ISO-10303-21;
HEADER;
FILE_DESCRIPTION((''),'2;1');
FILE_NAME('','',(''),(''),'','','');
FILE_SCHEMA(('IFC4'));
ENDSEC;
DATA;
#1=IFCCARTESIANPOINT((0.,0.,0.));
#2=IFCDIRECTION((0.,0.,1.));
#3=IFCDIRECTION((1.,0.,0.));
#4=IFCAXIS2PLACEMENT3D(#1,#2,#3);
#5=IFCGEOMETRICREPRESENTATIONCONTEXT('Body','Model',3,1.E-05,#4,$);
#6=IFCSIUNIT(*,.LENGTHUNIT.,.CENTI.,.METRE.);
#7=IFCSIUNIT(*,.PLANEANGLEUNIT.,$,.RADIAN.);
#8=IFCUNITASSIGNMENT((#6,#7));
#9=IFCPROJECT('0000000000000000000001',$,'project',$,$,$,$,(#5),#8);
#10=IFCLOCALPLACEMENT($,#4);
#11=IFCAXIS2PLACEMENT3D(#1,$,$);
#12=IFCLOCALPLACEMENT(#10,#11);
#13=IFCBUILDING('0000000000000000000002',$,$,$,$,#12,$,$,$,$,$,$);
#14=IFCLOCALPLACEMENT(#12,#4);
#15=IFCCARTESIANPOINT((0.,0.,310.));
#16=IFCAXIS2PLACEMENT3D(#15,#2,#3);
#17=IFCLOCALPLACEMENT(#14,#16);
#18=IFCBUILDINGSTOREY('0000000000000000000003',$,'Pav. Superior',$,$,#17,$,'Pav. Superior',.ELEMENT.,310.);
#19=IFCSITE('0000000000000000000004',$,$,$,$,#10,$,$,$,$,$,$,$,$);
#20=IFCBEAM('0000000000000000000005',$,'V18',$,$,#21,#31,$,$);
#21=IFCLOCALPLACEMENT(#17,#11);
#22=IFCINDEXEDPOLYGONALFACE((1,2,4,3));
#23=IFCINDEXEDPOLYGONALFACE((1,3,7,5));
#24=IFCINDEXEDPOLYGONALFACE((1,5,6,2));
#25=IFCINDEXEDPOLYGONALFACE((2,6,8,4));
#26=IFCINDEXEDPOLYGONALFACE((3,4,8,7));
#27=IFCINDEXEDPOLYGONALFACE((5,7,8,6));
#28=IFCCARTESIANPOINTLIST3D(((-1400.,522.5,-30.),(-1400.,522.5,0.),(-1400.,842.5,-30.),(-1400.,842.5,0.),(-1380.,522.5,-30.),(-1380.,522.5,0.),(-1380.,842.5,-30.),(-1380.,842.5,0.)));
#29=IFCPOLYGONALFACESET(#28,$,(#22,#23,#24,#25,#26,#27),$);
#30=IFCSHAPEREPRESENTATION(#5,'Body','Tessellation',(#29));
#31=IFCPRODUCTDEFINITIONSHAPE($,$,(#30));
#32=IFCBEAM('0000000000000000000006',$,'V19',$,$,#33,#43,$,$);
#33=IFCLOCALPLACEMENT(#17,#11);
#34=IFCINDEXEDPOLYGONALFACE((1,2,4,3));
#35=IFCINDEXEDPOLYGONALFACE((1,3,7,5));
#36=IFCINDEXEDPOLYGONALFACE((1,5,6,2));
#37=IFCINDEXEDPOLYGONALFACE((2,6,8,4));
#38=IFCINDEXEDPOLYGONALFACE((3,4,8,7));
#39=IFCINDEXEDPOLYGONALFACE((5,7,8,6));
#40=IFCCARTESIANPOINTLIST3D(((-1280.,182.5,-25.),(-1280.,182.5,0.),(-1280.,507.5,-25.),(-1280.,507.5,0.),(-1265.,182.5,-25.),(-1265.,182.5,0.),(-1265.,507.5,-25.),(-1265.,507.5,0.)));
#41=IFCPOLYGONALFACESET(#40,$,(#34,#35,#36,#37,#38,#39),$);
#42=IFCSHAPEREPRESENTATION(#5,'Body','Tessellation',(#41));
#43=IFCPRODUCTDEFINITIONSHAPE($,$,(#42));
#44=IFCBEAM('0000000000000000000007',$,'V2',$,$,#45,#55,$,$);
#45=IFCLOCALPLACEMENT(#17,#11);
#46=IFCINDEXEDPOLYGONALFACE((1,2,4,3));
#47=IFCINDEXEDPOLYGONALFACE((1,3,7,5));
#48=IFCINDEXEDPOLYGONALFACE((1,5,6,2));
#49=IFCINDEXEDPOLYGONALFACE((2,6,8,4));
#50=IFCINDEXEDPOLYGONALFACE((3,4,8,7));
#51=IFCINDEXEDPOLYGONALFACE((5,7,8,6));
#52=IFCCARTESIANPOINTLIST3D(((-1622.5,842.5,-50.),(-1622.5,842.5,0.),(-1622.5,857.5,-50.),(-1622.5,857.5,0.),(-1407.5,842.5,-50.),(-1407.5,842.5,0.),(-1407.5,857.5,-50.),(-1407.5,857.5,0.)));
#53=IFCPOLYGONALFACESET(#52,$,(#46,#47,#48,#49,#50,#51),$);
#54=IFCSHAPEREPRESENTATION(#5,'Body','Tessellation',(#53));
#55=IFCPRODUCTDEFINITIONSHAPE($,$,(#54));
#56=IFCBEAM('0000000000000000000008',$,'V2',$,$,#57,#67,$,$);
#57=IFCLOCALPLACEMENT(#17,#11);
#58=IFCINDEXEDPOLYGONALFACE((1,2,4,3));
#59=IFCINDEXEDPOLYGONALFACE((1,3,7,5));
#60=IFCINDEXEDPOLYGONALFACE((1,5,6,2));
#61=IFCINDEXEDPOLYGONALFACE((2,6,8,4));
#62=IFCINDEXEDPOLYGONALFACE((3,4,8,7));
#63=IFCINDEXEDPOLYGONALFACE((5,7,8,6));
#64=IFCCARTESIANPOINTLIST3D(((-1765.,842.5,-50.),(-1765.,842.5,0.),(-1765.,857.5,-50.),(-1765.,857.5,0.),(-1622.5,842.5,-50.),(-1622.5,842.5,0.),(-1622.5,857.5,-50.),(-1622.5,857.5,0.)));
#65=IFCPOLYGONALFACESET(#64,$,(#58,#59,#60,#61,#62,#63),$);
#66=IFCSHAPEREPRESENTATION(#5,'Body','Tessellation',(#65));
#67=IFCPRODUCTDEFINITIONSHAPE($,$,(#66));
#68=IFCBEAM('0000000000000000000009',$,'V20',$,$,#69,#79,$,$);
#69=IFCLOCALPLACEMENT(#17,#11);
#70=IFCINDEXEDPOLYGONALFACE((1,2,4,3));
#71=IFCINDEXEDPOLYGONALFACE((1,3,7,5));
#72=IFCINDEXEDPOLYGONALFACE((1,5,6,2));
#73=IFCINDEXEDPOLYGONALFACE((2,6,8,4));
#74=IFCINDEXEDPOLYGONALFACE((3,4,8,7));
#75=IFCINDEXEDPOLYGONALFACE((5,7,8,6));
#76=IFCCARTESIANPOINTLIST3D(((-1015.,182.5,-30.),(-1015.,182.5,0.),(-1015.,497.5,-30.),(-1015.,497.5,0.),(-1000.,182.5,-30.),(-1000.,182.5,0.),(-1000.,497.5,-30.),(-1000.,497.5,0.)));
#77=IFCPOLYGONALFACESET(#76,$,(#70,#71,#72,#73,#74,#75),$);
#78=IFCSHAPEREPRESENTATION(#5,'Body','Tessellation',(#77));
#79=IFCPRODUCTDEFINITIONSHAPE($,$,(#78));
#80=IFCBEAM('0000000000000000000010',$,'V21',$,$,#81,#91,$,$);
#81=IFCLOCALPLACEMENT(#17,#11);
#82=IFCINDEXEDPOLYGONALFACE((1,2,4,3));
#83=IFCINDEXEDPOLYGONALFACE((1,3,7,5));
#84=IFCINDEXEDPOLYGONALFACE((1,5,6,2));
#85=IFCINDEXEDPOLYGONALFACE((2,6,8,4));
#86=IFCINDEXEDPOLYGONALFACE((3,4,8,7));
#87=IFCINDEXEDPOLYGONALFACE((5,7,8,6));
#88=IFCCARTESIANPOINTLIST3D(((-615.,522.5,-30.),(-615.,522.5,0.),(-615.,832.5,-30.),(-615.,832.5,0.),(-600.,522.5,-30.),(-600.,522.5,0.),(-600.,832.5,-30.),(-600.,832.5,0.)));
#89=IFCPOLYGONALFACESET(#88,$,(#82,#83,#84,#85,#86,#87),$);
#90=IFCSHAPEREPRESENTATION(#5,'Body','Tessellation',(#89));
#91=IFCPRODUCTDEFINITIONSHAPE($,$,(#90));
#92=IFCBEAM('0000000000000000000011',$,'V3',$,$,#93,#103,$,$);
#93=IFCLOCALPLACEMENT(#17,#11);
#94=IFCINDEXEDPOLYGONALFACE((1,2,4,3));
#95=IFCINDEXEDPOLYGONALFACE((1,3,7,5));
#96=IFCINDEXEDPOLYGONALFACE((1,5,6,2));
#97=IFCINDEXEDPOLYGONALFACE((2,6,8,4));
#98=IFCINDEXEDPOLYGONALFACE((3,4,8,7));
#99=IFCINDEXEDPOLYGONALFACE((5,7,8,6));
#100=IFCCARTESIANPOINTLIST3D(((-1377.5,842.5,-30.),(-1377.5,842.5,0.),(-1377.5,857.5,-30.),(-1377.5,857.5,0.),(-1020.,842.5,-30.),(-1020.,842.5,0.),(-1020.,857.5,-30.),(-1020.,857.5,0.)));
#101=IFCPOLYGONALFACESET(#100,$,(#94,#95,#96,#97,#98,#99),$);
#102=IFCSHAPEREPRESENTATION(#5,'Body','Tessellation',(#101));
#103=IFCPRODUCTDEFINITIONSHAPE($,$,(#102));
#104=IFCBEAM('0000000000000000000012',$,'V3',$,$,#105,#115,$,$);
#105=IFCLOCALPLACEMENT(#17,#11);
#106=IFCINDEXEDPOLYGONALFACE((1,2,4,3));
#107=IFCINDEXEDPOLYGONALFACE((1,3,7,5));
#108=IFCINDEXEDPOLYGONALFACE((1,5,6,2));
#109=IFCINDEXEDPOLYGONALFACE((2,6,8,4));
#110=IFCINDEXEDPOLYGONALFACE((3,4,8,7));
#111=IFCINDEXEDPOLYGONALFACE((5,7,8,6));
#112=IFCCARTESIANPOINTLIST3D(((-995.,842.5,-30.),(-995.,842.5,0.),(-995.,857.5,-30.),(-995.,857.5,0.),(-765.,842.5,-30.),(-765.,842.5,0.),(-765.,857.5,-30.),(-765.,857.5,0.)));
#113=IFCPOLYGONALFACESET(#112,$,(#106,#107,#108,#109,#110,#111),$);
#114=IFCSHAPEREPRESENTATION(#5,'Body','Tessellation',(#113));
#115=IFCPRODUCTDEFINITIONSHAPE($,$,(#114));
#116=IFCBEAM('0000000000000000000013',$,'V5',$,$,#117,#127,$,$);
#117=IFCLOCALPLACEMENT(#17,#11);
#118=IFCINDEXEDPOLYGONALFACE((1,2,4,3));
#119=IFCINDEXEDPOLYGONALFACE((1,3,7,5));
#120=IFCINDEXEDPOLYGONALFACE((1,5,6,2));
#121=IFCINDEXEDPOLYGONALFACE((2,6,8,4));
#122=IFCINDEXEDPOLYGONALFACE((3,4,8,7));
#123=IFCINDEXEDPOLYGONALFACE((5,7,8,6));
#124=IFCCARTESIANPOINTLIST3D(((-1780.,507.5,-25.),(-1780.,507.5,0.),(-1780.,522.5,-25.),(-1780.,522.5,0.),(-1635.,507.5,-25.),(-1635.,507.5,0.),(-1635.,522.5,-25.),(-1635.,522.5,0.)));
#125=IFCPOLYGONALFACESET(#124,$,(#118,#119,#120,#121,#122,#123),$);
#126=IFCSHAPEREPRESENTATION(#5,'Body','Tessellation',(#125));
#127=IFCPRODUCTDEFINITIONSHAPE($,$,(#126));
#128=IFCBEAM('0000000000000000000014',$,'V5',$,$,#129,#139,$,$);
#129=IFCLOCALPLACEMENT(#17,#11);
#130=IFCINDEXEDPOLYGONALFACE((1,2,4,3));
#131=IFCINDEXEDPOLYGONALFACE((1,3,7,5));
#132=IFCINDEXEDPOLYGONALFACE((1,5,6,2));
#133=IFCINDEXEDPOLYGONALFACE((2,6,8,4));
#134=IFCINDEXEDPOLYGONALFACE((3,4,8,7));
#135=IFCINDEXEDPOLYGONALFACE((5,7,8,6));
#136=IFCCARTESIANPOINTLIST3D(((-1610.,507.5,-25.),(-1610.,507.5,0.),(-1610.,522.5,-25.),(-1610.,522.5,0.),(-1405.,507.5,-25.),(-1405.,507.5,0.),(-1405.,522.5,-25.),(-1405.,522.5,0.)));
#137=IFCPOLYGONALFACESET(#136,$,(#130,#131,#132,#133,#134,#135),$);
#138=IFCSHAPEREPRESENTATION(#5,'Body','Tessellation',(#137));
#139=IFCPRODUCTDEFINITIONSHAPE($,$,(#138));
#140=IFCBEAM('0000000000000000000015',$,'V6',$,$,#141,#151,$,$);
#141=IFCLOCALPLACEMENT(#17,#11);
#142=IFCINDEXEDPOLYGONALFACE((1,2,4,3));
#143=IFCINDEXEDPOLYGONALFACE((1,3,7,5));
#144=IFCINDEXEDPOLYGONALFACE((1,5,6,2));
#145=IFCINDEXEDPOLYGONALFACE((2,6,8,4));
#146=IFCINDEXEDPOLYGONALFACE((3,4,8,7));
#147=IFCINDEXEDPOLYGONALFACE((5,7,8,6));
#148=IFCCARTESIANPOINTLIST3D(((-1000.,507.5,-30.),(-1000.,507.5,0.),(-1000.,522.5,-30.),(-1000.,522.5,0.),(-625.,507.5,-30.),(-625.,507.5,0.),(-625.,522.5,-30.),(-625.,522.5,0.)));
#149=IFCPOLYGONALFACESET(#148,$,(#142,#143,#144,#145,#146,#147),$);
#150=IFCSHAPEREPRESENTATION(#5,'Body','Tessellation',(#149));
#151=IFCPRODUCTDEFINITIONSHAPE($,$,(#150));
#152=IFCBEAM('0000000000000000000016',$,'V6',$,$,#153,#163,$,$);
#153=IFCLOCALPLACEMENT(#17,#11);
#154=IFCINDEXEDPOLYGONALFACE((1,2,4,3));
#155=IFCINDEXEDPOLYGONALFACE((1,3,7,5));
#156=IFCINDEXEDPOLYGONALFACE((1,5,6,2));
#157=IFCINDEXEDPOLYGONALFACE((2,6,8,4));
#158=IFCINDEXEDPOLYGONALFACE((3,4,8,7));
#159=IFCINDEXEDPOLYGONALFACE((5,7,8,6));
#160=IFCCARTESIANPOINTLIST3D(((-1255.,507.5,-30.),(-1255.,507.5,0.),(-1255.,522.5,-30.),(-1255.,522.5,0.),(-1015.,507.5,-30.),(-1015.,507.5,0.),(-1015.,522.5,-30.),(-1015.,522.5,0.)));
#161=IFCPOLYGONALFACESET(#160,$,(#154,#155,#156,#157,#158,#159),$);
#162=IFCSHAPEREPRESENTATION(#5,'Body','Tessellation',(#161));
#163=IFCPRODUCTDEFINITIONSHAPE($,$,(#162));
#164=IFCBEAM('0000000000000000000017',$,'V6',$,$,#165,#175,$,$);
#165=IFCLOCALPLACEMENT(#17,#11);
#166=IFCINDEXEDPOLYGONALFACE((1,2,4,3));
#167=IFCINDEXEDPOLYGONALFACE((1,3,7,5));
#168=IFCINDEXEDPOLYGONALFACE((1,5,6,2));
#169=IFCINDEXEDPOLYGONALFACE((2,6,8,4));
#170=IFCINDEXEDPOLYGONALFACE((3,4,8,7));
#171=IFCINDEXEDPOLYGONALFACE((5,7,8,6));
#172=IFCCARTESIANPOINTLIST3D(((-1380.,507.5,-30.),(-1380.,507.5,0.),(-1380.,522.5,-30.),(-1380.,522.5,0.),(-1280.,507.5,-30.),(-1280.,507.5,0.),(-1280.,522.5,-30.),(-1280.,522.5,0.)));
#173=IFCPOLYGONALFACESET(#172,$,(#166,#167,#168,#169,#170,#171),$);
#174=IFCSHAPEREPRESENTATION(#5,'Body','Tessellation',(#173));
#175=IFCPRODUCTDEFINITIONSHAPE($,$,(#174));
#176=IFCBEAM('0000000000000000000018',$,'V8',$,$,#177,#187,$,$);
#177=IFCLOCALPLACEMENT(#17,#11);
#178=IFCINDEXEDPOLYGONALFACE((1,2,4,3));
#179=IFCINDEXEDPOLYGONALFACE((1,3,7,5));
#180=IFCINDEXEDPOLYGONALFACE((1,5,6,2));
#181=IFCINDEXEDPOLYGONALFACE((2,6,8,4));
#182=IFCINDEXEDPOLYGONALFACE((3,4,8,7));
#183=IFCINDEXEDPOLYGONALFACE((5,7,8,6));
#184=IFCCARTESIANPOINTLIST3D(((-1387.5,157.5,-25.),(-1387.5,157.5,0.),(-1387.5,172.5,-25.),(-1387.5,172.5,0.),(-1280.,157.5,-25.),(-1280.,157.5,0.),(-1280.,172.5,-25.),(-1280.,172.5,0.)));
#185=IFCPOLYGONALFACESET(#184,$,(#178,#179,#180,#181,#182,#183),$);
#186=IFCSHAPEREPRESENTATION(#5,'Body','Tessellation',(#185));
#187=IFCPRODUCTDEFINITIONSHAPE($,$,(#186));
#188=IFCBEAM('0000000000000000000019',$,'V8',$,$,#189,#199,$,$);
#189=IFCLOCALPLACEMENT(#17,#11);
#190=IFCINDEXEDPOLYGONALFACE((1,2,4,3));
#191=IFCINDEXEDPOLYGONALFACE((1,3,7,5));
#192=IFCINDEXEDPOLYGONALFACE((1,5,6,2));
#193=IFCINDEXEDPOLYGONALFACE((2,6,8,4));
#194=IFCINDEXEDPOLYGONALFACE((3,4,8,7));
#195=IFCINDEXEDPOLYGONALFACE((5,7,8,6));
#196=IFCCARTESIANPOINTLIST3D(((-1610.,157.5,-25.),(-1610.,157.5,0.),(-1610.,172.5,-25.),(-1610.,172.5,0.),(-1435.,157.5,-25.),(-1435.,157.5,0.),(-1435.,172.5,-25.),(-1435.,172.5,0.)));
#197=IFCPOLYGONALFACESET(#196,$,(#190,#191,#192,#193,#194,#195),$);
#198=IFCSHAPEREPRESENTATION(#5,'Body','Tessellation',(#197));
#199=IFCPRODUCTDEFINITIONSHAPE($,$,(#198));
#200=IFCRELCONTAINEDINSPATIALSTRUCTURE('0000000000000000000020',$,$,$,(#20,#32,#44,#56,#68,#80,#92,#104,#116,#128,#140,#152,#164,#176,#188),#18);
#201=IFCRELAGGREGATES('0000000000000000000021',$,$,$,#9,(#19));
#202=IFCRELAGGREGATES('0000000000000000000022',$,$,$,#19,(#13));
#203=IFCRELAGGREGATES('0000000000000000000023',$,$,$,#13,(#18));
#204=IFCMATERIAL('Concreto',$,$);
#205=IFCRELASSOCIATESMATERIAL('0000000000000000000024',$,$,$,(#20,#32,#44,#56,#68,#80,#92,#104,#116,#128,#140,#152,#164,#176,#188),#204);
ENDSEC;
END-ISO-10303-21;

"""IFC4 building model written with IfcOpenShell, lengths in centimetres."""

from ifc_helpers import new_model, si_unit, frame, origin, origin_with_axes, origin_2d_with_axis, place, context, project, spatial, rectangle, extrude, material, element, save


model = new_model("IFC4")

# Units and contexts
model_context = context("Model", 3, precision=1e-05, world=origin_with_axes(), identifier="Body")
ifc_project = project(units=[si_unit("LENGTHUNIT", "METRE", prefix="CENTI"), si_unit("PLANEANGLEUNIT", "RADIAN")], contexts=[model_context])

# Site, building, storey
site_placement = place(None, origin_with_axes())
site = spatial("IfcSite", under=ifc_project, at=site_placement)
building_placement = place(site_placement, origin())
building = spatial("IfcBuilding", under=site, at=building_placement)
placement = place(building_placement, origin_with_axes())
storey_placement = place(placement, frame((0.0, 0.0, 310.0), z_axis=(0.0, 0.0, 1.0), x_axis=(1.0, 0.0, 0.0)))
storey = spatial("IfcBuildingStorey", under=building, at=storey_placement, Name="Pav. Superior", LongName="Pav. Superior", CompositionType="ELEMENT", Elevation=310.0)

# Shared definitions
ifc_material = material(Name="Concreto")

# Beams
beam_1_placement = place(storey_placement, frame((-1390.0, 682.5, 0.0), z_axis=(0.0, 0.0, 1.0), x_axis=(1.0, 0.0, 0.0)))
element("IfcBeam", 1, at=beam_1_placement, inside=storey, material=ifc_material, Name="V18", context=model_context, shape_type="SolidModel", body=[
    extrude(rectangle(XDim=20.0, YDim=30.0, at=origin_2d_with_axis()), frame((0.0, -160.0, -15.0), z_axis=(0.0, 1.0, 0.0), x_axis=(-1.0, 0.0, 0.0)), (0.0, 0.0, 1.0), 320.0),
])
beam_2_placement = place(storey_placement, frame((-1272.5, 345.0, 0.0), z_axis=(0.0, 0.0, 1.0), x_axis=(1.0, 0.0, 0.0)))
element("IfcBeam", 2, at=beam_2_placement, inside=storey, material=ifc_material, Name="V19", context=model_context, shape_type="SolidModel", body=[
    extrude(rectangle(XDim=15.0, YDim=25.0, at=origin_2d_with_axis()), frame((0.0, -162.5, -12.5), z_axis=(0.0, 1.0, 0.0), x_axis=(-1.0, 0.0, 0.0)), (0.0, 0.0, 1.0), 325.0),
])
beam_3_placement = place(storey_placement, frame((-1515.0, 850.0, 0.0), z_axis=(0.0, 0.0, 1.0), x_axis=(1.0, 0.0, 0.0)))
element("IfcBeam", 3, at=beam_3_placement, inside=storey, material=ifc_material, Name="V2", context=model_context, shape_type="SolidModel", body=[
    extrude(rectangle(XDim=15.0, YDim=50.0, at=origin_2d_with_axis()), frame((-107.5, 0.0, -25.0), z_axis=(1.0, 0.0, 0.0), x_axis=(0.0, -1.0, 0.0)), (0.0, 0.0, 1.0), 215.0),
])
beam_4_placement = place(storey_placement, frame((-1693.75, 850.0, 0.0), z_axis=(0.0, 0.0, 1.0), x_axis=(1.0, 0.0, 0.0)))
element("IfcBeam", 4, at=beam_4_placement, inside=storey, material=ifc_material, Name="V2", context=model_context, shape_type="SolidModel", body=[
    extrude(rectangle(XDim=15.0, YDim=50.0, at=origin_2d_with_axis()), frame((-71.25, 0.0, -25.0), z_axis=(1.0, 0.0, 0.0), x_axis=(0.0, -1.0, 0.0)), (0.0, 0.0, 1.0), 142.5),
])
beam_5_placement = place(storey_placement, frame((-1007.5, 340.0, 0.0), z_axis=(0.0, 0.0, 1.0), x_axis=(1.0, 0.0, 0.0)))
element("IfcBeam", 5, at=beam_5_placement, inside=storey, material=ifc_material, Name="V20", context=model_context, shape_type="SolidModel", body=[
    extrude(rectangle(XDim=15.0, YDim=30.0, at=origin_2d_with_axis()), frame((0.0, -157.5, -15.0), z_axis=(0.0, 1.0, 0.0), x_axis=(-1.0, 0.0, 0.0)), (0.0, 0.0, 1.0), 315.0),
])
beam_6_placement = place(storey_placement, frame((-607.5, 677.5, 0.0), z_axis=(0.0, 0.0, 1.0), x_axis=(1.0, 0.0, 0.0)))
element("IfcBeam", 6, at=beam_6_placement, inside=storey, material=ifc_material, Name="V21", context=model_context, shape_type="SolidModel", body=[
    extrude(rectangle(XDim=15.0, YDim=30.0, at=origin_2d_with_axis()), frame((0.0, -155.0, -15.0), z_axis=(0.0, 1.0, 0.0), x_axis=(-1.0, 0.0, 0.0)), (0.0, 0.0, 1.0), 310.0),
])
beam_7_placement = place(storey_placement, frame((-1198.75, 850.0, 0.0), z_axis=(0.0, 0.0, 1.0), x_axis=(1.0, 0.0, 0.0)))
element("IfcBeam", 7, at=beam_7_placement, inside=storey, material=ifc_material, Name="V3", context=model_context, shape_type="SolidModel", body=[
    extrude(rectangle(XDim=15.0, YDim=30.0, at=origin_2d_with_axis()), frame((-178.75, 0.0, -15.0), z_axis=(1.0, 0.0, 0.0), x_axis=(0.0, -1.0, 0.0)), (0.0, 0.0, 1.0), 357.5),
])
beam_8_placement = place(storey_placement, frame((-880.0, 850.0, 0.0), z_axis=(0.0, 0.0, 1.0), x_axis=(1.0, 0.0, 0.0)))
element("IfcBeam", 8, at=beam_8_placement, inside=storey, material=ifc_material, Name="V3", context=model_context, shape_type="SolidModel", body=[
    extrude(rectangle(XDim=15.0, YDim=30.0, at=origin_2d_with_axis()), frame((-115.0, 0.0, -15.0), z_axis=(1.0, 0.0, 0.0), x_axis=(0.0, 1.0, 0.0)), (0.0, 0.0, 1.0), 230.0),
])
beam_9_placement = place(storey_placement, frame((-1707.5, 515.0, 0.0), z_axis=(0.0, 0.0, 1.0), x_axis=(1.0, 0.0, 0.0)))
element("IfcBeam", 9, at=beam_9_placement, inside=storey, material=ifc_material, Name="V5", context=model_context, shape_type="SolidModel", body=[
    extrude(rectangle(XDim=15.0, YDim=25.0, at=origin_2d_with_axis()), frame((-72.5, 0.0, -12.5), z_axis=(1.0, 0.0, 0.0), x_axis=(0.0, -1.0, 0.0)), (0.0, 0.0, 1.0), 145.0),
])
beam_10_placement = place(storey_placement, frame((-1507.5, 515.0, 0.0), z_axis=(0.0, 0.0, 1.0), x_axis=(1.0, 0.0, 0.0)))
element("IfcBeam", 10, at=beam_10_placement, inside=storey, material=ifc_material, Name="V5", context=model_context, shape_type="SolidModel", body=[
    extrude(rectangle(XDim=15.0, YDim=25.0, at=origin_2d_with_axis()), frame((-102.5, 0.0, -12.5), z_axis=(1.0, 0.0, 0.0), x_axis=(0.0, -1.0, 0.0)), (0.0, 0.0, 1.0), 205.0),
])
beam_11_placement = place(storey_placement, frame((-812.5, 515.0, 0.0), z_axis=(0.0, 0.0, 1.0), x_axis=(1.0, 0.0, 0.0)))
element("IfcBeam", 11, at=beam_11_placement, inside=storey, material=ifc_material, Name="V6", context=model_context, shape_type="SolidModel", body=[
    extrude(rectangle(XDim=15.0, YDim=30.0, at=origin_2d_with_axis()), frame((-187.5, 0.0, -15.0), z_axis=(1.0, 0.0, 0.0), x_axis=(0.0, -1.0, 0.0)), (0.0, 0.0, 1.0), 375.0),
])
beam_12_placement = place(storey_placement, frame((-1135.0, 515.0, 0.0), z_axis=(0.0, 0.0, 1.0), x_axis=(1.0, 0.0, 0.0)))
element("IfcBeam", 12, at=beam_12_placement, inside=storey, material=ifc_material, Name="V6", context=model_context, shape_type="SolidModel", body=[
    extrude(rectangle(XDim=15.0, YDim=30.0, at=origin_2d_with_axis()), frame((-120.0, 0.0, -15.0), z_axis=(1.0, 0.0, 0.0), x_axis=(0.0, -1.0, 0.0)), (0.0, 0.0, 1.0), 240.0),
])
beam_13_placement = place(storey_placement, frame((-1330.0, 515.0, 0.0), z_axis=(0.0, 0.0, 1.0), x_axis=(1.0, 0.0, 0.0)))
element("IfcBeam", 13, at=beam_13_placement, inside=storey, material=ifc_material, Name="V6", context=model_context, shape_type="SolidModel", body=[
    extrude(rectangle(XDim=15.0, YDim=30.0, at=origin_2d_with_axis()), frame((-50.0, 0.0, -15.0), z_axis=(1.0, 0.0, 0.0), x_axis=(0.0, -1.0, 0.0)), (0.0, 0.0, 1.0), 100.0),
])
beam_14_placement = place(storey_placement, frame((-1333.75, 165.0, 0.0), z_axis=(0.0, 0.0, 1.0), x_axis=(1.0, 0.0, 0.0)))
element("IfcBeam", 14, at=beam_14_placement, inside=storey, material=ifc_material, Name="V8", context=model_context, shape_type="SolidModel", body=[
    extrude(rectangle(XDim=15.0, YDim=25.0, at=origin_2d_with_axis()), frame((-53.75, 0.0, -12.5), z_axis=(1.0, 0.0, 0.0), x_axis=(0.0, -1.0, 0.0)), (0.0, 0.0, 1.0), 107.5),
])
beam_15_placement = place(storey_placement, frame((-1522.5, 165.0, 0.0), z_axis=(0.0, 0.0, 1.0), x_axis=(1.0, 0.0, 0.0)))
element("IfcBeam", 15, at=beam_15_placement, inside=storey, material=ifc_material, Name="V8", context=model_context, shape_type="SolidModel", body=[
    extrude(rectangle(XDim=15.0, YDim=25.0, at=origin_2d_with_axis()), frame((-87.5, 0.0, -12.5), z_axis=(1.0, 0.0, 0.0), x_axis=(0.0, -1.0, 0.0)), (0.0, 0.0, 1.0), 175.0),
])

save(model, "model.ifc")
